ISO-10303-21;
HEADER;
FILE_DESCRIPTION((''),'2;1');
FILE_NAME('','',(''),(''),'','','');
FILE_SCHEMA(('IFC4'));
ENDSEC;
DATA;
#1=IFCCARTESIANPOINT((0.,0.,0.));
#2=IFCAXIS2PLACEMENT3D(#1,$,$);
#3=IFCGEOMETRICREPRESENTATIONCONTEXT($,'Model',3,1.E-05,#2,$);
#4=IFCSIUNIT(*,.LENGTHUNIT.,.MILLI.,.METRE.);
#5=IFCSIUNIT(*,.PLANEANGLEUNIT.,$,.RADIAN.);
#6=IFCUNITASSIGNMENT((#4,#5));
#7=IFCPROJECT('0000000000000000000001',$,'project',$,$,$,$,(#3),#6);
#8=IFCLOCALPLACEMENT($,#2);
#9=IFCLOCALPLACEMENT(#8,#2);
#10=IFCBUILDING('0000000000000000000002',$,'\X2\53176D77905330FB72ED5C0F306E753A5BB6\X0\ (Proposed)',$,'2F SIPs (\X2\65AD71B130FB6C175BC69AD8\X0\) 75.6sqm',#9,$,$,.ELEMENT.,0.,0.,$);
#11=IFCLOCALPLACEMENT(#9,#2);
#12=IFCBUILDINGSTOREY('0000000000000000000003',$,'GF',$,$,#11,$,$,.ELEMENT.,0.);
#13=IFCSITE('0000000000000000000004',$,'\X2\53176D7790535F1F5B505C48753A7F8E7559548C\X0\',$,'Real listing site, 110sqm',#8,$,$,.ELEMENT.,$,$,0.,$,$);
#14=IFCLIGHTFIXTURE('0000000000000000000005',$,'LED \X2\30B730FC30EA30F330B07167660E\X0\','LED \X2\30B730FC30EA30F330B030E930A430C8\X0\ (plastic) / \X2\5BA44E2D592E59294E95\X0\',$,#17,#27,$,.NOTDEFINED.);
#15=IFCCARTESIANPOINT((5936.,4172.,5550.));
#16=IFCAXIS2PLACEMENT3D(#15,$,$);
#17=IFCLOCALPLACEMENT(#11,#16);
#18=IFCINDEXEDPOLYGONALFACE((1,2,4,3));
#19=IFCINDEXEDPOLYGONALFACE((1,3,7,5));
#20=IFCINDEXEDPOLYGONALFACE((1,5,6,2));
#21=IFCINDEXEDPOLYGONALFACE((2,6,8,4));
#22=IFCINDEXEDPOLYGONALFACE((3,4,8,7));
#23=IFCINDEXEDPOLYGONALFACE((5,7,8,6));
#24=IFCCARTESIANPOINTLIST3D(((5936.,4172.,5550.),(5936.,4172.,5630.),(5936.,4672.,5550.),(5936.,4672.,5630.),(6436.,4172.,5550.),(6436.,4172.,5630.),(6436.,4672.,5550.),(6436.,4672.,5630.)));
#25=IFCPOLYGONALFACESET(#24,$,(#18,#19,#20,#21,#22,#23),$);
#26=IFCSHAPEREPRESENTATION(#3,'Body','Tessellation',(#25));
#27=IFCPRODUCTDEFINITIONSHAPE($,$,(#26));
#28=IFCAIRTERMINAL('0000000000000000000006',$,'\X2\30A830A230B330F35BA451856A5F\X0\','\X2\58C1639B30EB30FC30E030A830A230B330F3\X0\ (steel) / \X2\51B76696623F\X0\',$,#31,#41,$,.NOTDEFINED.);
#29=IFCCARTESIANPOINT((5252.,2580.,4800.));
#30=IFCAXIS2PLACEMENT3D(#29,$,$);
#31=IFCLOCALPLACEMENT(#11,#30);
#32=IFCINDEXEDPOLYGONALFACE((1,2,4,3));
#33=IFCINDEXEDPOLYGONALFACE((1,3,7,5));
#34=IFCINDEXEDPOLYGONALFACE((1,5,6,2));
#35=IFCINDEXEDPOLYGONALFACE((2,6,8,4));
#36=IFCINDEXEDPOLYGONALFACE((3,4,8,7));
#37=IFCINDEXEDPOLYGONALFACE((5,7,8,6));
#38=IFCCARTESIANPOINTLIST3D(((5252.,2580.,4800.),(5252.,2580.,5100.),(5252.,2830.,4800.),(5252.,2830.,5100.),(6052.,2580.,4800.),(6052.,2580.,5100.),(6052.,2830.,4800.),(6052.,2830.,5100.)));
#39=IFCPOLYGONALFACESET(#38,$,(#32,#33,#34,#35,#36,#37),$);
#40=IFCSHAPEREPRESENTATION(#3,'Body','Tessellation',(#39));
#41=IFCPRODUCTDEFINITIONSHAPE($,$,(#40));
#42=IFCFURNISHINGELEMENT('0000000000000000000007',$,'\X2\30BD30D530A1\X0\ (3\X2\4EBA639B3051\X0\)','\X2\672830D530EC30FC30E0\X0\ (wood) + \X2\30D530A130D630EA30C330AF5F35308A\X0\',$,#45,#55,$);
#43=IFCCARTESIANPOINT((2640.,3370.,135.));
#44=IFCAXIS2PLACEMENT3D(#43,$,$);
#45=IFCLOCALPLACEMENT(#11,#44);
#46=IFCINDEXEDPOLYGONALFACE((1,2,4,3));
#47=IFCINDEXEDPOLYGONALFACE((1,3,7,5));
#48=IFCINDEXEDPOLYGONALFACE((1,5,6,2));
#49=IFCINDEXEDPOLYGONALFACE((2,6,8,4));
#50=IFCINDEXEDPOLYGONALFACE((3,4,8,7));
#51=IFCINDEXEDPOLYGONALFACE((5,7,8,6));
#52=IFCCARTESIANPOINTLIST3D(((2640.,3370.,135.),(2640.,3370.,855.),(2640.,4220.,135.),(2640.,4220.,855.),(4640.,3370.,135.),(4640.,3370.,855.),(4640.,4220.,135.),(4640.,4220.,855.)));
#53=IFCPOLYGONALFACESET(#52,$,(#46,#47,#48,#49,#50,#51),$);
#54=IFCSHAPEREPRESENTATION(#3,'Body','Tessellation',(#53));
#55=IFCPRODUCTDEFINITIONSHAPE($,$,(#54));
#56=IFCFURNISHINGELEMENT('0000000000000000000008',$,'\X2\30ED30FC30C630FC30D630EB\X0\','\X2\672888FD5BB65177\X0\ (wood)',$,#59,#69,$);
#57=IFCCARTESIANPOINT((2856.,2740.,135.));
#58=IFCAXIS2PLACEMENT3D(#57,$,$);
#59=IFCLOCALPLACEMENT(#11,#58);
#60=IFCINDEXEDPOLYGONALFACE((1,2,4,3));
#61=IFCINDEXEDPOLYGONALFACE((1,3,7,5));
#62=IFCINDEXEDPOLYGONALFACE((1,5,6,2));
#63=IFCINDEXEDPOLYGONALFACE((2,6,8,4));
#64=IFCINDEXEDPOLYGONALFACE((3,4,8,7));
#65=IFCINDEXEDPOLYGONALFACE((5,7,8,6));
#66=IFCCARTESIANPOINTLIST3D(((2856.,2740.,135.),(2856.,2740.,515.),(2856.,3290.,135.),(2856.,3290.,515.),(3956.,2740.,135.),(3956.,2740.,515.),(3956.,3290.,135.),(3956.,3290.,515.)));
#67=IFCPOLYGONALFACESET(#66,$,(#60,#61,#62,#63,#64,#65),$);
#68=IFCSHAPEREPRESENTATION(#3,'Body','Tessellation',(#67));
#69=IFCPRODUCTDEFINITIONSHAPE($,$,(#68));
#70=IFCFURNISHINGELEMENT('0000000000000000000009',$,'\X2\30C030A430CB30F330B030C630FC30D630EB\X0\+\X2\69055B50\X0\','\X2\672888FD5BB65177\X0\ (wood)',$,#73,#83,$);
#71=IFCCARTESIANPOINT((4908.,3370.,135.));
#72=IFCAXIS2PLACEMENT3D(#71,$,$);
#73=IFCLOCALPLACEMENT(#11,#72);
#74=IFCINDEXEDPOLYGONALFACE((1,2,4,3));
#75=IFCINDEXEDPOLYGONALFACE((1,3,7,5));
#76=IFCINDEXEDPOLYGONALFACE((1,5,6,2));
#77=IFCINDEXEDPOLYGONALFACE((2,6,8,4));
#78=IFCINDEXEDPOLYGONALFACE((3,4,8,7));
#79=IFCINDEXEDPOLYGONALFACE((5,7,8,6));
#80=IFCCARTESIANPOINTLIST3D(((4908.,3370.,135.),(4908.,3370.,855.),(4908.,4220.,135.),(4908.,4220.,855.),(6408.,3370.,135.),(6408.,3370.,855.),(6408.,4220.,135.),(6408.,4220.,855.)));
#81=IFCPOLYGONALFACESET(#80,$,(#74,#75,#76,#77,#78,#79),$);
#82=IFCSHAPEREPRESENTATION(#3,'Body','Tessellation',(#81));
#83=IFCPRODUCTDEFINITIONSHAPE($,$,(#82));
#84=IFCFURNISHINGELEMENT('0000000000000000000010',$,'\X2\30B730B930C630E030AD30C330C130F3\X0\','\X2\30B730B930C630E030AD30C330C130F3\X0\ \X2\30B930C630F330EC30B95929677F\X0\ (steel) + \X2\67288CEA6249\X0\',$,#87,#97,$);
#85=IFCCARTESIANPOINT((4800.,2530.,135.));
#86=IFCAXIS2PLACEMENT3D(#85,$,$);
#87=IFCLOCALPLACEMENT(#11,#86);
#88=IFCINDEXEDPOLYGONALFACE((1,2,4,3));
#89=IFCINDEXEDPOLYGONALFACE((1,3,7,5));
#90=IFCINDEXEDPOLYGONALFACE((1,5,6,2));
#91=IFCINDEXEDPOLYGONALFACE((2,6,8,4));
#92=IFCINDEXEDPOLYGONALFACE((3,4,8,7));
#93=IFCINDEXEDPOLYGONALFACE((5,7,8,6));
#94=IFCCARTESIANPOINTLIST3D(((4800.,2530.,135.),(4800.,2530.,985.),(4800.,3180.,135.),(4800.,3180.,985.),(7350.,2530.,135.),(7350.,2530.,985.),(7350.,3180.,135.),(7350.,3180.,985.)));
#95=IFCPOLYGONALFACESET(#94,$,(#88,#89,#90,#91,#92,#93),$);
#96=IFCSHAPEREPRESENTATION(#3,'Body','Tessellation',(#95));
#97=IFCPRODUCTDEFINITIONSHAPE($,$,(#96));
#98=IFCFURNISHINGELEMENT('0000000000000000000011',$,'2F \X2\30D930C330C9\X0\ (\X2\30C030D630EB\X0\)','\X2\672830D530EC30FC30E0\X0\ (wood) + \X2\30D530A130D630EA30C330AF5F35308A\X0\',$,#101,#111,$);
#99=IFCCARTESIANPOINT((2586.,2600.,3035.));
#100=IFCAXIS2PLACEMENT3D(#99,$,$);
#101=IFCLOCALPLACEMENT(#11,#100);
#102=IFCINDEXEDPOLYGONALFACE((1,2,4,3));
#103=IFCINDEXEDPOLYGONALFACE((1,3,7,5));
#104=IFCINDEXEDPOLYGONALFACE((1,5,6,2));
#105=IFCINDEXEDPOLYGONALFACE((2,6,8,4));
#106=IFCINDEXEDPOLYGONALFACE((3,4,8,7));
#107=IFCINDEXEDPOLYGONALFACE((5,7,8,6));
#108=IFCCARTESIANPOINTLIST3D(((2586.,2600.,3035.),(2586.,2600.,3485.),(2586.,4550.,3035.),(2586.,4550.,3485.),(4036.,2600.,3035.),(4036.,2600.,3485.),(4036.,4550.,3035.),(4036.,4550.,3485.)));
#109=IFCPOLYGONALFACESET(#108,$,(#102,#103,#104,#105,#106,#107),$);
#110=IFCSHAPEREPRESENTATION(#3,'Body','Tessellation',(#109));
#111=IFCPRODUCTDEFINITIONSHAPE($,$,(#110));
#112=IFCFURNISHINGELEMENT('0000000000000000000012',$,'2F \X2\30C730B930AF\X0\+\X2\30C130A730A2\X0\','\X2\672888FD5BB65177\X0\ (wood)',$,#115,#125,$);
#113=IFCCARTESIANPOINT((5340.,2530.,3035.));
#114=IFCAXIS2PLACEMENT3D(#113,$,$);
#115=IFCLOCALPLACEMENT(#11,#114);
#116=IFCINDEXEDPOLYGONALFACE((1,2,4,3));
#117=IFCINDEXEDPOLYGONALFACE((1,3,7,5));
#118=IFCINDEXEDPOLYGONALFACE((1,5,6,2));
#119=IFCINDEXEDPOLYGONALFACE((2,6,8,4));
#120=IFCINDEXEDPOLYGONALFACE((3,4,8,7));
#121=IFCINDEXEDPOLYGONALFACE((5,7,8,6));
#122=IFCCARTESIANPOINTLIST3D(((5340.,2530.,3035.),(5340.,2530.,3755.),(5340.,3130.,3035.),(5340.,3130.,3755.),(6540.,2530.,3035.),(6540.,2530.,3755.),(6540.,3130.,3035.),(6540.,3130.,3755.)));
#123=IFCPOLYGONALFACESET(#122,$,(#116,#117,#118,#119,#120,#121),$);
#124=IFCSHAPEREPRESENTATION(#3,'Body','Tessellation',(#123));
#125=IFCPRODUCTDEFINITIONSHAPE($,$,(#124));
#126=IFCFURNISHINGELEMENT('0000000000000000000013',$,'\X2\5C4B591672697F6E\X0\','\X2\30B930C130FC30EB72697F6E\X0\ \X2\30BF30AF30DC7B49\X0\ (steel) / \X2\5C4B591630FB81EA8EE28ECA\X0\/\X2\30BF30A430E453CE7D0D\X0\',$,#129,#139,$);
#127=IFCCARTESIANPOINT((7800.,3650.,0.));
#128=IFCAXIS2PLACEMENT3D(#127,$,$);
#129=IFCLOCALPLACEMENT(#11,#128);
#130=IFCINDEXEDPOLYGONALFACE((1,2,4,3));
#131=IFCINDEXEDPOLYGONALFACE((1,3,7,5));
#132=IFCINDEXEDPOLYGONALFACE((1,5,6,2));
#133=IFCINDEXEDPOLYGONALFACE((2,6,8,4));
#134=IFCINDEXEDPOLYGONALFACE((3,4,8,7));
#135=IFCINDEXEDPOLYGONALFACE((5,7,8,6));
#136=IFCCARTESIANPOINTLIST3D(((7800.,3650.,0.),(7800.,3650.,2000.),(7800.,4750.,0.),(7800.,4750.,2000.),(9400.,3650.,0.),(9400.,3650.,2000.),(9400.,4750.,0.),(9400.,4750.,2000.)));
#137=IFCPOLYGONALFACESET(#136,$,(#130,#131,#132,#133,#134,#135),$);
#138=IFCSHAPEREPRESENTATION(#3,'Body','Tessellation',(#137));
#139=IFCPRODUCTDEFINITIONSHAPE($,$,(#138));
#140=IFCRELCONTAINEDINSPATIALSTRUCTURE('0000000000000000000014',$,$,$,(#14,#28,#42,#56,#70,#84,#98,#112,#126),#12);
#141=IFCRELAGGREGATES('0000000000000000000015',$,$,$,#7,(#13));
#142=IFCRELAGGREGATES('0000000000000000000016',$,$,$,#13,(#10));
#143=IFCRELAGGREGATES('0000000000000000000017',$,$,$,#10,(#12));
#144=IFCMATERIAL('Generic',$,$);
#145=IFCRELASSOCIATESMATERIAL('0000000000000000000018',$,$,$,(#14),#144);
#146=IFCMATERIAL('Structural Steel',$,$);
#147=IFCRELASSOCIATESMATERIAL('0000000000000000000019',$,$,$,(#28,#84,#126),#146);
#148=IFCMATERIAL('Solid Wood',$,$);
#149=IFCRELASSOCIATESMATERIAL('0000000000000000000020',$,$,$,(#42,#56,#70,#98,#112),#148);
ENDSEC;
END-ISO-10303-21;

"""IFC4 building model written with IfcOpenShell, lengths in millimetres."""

from ifc_helpers import new_model, si_unit, frame, frame_2d, origin, place, context, project, spatial, rectangle, extrude, material, element, save


model = new_model("IFC4")

# Units and contexts
model_context = context("Model", 3, precision=1e-05, world=origin())
ifc_project = project(units=[si_unit("LENGTHUNIT", "METRE", prefix="MILLI"), si_unit("PLANEANGLEUNIT", "RADIAN")], contexts=[model_context])

# Site, building, storey
site_placement = place(None, origin())
site = spatial("IfcSite", under=ifc_project, at=site_placement, Name="北海道弟子屈町美留和", ObjectType="Real listing site, 110sqm", CompositionType="ELEMENT", RefElevation=0.0)
building_placement = place(site_placement, origin())
building = spatial("IfcBuilding", under=site, at=building_placement, Name="北海道・狭小の町家 (Proposed)", ObjectType="2F SIPs (断熱・気密高) 75.6sqm", CompositionType="ELEMENT", ElevationOfRefHeight=0.0, ElevationOfTerrain=0.0)
storey_placement = place(building_placement, origin())
storey = spatial("IfcBuildingStorey", under=building, at=storey_placement, Name="GF", CompositionType="ELEMENT", Elevation=0.0)

# Shared definitions
ifc_material_1 = material(Name="Solid Wood")

# Shared definitions
ifc_material_2 = material(Name="Generic")

# Shared definitions
ifc_material_3 = material(Name="Structural Steel")

# Light fixture
light_fixture_placement = place(storey_placement, frame((5936.0, 4172.0, 5550.0)))
element("IfcLightFixture", 1, at=light_fixture_placement, inside=storey, material=ifc_material_2, Name="LED シーリング照明", Description="LED シーリングライト (plastic) / 室中央天井", PredefinedType="NOTDEFINED", context=model_context, shape_type="SweptSolid", body=[
    extrude(rectangle(XDim=500.0, YDim=500.0, at=frame_2d((250.0, 250.0))), frame((5936.0, 4172.0, 5550.0)), (0.0, 0.0, 1.0), 80.0),
])

# Air terminal
air_terminal_1_placement = place(storey_placement, frame((5252.0, 2580.0, 4800.0)))
element("IfcAirTerminal", 2, at=air_terminal_1_placement, inside=storey, material=ifc_material_3, Name="エアコン室内機", Description="壁掛ルームエアコン (steel) / 冷暖房", PredefinedType="NOTDEFINED", context=model_context, shape_type="SweptSolid", body=[
    extrude(rectangle(XDim=800.0, YDim=250.0, at=frame_2d((400.0, 125.0))), frame((5252.0, 2580.0, 4800.0)), (0.0, 0.0, 1.0), 300.0),
])

# Furnishing elements
furnishing_1_placement = place(storey_placement, frame((2640.0, 3370.0, 135.0)))
element("IfcFurnishingElement", 3, at=furnishing_1_placement, inside=storey, material=ifc_material_1, Name="ソファ (3人掛け)", Description="木フレーム (wood) + ファブリック張り", context=model_context, shape_type="SweptSolid", body=[
    extrude(rectangle(XDim=2000.0, YDim=850.0, at=frame_2d((1000.0, 425.0))), frame((2640.0, 3370.0, 135.0)), (0.0, 0.0, 1.0), 720.0),
])
furnishing_2_placement = place(storey_placement, frame((2856.0, 2740.0, 135.0)))
element("IfcFurnishingElement", 4, at=furnishing_2_placement, inside=storey, material=ifc_material_1, Name="ローテーブル", Description="木製家具 (wood)", context=model_context, shape_type="SweptSolid", body=[
    extrude(rectangle(XDim=1100.0, YDim=550.0, at=frame_2d((550.0, 275.0))), frame((2856.0, 2740.0, 135.0)), (0.0, 0.0, 1.0), 380.0),
])
furnishing_3_placement = place(storey_placement, frame((4908.0, 3370.0, 135.0)))
element("IfcFurnishingElement", 5, at=furnishing_3_placement, inside=storey, material=ifc_material_1, Name="ダイニングテーブル+椅子", Description="木製家具 (wood)", context=model_context, shape_type="SweptSolid", body=[
    extrude(rectangle(XDim=1500.0, YDim=850.0, at=frame_2d((750.0, 425.0))), frame((4908.0, 3370.0, 135.0)), (0.0, 0.0, 1.0), 720.0),
])
furnishing_4_placement = place(storey_placement, frame((4800.0, 2530.0, 135.0)))
element("IfcFurnishingElement", 6, at=furnishing_4_placement, inside=storey, material=ifc_material_3, Name="システムキッチン", Description="システムキッチン ステンレス天板 (steel) + 木質扉", context=model_context, shape_type="SweptSolid", body=[
    extrude(rectangle(XDim=2550.0, YDim=650.0, at=frame_2d((1275.0, 325.0))), frame((4800.0, 2530.0, 135.0)), (0.0, 0.0, 1.0), 850.0),
])
furnishing_5_placement = place(storey_placement, frame((2586.0, 2600.0, 3035.0)))
element("IfcFurnishingElement", 7, at=furnishing_5_placement, inside=storey, material=ifc_material_1, Name="2F ベッド (ダブル)", Description="木フレーム (wood) + ファブリック張り", context=model_context, shape_type="SweptSolid", body=[
    extrude(rectangle(XDim=1450.0, YDim=1950.0, at=frame_2d((725.0, 975.0))), frame((2586.0, 2600.0, 3035.0)), (0.0, 0.0, 1.0), 450.0),
])
furnishing_6_placement = place(storey_placement, frame((5340.0, 2530.0, 3035.0)))
element("IfcFurnishingElement", 8, at=furnishing_6_placement, inside=storey, material=ifc_material_1, Name="2F デスク+チェア", Description="木製家具 (wood)", context=model_context, shape_type="SweptSolid", body=[
    extrude(rectangle(XDim=1200.0, YDim=600.0, at=frame_2d((600.0, 300.0))), frame((5340.0, 2530.0, 3035.0)), (0.0, 0.0, 1.0), 720.0),
])
furnishing_7_placement = place(storey_placement, frame((7800.0, 3650.0, 0.0)))
element("IfcFurnishingElement", 9, at=furnishing_7_placement, inside=storey, material=ifc_material_3, Name="屋外物置", Description="スチール物置 タクボ等 (steel) / 屋外・自転車/タイヤ収納", context=model_context, shape_type="SweptSolid", body=[
    extrude(rectangle(XDim=1600.0, YDim=1100.0, at=frame_2d((800.0, 550.0))), frame((7800.0, 3650.0, 0.0)), (0.0, 0.0, 1.0), 2000.0),
])

save(model, "model.ifc")
